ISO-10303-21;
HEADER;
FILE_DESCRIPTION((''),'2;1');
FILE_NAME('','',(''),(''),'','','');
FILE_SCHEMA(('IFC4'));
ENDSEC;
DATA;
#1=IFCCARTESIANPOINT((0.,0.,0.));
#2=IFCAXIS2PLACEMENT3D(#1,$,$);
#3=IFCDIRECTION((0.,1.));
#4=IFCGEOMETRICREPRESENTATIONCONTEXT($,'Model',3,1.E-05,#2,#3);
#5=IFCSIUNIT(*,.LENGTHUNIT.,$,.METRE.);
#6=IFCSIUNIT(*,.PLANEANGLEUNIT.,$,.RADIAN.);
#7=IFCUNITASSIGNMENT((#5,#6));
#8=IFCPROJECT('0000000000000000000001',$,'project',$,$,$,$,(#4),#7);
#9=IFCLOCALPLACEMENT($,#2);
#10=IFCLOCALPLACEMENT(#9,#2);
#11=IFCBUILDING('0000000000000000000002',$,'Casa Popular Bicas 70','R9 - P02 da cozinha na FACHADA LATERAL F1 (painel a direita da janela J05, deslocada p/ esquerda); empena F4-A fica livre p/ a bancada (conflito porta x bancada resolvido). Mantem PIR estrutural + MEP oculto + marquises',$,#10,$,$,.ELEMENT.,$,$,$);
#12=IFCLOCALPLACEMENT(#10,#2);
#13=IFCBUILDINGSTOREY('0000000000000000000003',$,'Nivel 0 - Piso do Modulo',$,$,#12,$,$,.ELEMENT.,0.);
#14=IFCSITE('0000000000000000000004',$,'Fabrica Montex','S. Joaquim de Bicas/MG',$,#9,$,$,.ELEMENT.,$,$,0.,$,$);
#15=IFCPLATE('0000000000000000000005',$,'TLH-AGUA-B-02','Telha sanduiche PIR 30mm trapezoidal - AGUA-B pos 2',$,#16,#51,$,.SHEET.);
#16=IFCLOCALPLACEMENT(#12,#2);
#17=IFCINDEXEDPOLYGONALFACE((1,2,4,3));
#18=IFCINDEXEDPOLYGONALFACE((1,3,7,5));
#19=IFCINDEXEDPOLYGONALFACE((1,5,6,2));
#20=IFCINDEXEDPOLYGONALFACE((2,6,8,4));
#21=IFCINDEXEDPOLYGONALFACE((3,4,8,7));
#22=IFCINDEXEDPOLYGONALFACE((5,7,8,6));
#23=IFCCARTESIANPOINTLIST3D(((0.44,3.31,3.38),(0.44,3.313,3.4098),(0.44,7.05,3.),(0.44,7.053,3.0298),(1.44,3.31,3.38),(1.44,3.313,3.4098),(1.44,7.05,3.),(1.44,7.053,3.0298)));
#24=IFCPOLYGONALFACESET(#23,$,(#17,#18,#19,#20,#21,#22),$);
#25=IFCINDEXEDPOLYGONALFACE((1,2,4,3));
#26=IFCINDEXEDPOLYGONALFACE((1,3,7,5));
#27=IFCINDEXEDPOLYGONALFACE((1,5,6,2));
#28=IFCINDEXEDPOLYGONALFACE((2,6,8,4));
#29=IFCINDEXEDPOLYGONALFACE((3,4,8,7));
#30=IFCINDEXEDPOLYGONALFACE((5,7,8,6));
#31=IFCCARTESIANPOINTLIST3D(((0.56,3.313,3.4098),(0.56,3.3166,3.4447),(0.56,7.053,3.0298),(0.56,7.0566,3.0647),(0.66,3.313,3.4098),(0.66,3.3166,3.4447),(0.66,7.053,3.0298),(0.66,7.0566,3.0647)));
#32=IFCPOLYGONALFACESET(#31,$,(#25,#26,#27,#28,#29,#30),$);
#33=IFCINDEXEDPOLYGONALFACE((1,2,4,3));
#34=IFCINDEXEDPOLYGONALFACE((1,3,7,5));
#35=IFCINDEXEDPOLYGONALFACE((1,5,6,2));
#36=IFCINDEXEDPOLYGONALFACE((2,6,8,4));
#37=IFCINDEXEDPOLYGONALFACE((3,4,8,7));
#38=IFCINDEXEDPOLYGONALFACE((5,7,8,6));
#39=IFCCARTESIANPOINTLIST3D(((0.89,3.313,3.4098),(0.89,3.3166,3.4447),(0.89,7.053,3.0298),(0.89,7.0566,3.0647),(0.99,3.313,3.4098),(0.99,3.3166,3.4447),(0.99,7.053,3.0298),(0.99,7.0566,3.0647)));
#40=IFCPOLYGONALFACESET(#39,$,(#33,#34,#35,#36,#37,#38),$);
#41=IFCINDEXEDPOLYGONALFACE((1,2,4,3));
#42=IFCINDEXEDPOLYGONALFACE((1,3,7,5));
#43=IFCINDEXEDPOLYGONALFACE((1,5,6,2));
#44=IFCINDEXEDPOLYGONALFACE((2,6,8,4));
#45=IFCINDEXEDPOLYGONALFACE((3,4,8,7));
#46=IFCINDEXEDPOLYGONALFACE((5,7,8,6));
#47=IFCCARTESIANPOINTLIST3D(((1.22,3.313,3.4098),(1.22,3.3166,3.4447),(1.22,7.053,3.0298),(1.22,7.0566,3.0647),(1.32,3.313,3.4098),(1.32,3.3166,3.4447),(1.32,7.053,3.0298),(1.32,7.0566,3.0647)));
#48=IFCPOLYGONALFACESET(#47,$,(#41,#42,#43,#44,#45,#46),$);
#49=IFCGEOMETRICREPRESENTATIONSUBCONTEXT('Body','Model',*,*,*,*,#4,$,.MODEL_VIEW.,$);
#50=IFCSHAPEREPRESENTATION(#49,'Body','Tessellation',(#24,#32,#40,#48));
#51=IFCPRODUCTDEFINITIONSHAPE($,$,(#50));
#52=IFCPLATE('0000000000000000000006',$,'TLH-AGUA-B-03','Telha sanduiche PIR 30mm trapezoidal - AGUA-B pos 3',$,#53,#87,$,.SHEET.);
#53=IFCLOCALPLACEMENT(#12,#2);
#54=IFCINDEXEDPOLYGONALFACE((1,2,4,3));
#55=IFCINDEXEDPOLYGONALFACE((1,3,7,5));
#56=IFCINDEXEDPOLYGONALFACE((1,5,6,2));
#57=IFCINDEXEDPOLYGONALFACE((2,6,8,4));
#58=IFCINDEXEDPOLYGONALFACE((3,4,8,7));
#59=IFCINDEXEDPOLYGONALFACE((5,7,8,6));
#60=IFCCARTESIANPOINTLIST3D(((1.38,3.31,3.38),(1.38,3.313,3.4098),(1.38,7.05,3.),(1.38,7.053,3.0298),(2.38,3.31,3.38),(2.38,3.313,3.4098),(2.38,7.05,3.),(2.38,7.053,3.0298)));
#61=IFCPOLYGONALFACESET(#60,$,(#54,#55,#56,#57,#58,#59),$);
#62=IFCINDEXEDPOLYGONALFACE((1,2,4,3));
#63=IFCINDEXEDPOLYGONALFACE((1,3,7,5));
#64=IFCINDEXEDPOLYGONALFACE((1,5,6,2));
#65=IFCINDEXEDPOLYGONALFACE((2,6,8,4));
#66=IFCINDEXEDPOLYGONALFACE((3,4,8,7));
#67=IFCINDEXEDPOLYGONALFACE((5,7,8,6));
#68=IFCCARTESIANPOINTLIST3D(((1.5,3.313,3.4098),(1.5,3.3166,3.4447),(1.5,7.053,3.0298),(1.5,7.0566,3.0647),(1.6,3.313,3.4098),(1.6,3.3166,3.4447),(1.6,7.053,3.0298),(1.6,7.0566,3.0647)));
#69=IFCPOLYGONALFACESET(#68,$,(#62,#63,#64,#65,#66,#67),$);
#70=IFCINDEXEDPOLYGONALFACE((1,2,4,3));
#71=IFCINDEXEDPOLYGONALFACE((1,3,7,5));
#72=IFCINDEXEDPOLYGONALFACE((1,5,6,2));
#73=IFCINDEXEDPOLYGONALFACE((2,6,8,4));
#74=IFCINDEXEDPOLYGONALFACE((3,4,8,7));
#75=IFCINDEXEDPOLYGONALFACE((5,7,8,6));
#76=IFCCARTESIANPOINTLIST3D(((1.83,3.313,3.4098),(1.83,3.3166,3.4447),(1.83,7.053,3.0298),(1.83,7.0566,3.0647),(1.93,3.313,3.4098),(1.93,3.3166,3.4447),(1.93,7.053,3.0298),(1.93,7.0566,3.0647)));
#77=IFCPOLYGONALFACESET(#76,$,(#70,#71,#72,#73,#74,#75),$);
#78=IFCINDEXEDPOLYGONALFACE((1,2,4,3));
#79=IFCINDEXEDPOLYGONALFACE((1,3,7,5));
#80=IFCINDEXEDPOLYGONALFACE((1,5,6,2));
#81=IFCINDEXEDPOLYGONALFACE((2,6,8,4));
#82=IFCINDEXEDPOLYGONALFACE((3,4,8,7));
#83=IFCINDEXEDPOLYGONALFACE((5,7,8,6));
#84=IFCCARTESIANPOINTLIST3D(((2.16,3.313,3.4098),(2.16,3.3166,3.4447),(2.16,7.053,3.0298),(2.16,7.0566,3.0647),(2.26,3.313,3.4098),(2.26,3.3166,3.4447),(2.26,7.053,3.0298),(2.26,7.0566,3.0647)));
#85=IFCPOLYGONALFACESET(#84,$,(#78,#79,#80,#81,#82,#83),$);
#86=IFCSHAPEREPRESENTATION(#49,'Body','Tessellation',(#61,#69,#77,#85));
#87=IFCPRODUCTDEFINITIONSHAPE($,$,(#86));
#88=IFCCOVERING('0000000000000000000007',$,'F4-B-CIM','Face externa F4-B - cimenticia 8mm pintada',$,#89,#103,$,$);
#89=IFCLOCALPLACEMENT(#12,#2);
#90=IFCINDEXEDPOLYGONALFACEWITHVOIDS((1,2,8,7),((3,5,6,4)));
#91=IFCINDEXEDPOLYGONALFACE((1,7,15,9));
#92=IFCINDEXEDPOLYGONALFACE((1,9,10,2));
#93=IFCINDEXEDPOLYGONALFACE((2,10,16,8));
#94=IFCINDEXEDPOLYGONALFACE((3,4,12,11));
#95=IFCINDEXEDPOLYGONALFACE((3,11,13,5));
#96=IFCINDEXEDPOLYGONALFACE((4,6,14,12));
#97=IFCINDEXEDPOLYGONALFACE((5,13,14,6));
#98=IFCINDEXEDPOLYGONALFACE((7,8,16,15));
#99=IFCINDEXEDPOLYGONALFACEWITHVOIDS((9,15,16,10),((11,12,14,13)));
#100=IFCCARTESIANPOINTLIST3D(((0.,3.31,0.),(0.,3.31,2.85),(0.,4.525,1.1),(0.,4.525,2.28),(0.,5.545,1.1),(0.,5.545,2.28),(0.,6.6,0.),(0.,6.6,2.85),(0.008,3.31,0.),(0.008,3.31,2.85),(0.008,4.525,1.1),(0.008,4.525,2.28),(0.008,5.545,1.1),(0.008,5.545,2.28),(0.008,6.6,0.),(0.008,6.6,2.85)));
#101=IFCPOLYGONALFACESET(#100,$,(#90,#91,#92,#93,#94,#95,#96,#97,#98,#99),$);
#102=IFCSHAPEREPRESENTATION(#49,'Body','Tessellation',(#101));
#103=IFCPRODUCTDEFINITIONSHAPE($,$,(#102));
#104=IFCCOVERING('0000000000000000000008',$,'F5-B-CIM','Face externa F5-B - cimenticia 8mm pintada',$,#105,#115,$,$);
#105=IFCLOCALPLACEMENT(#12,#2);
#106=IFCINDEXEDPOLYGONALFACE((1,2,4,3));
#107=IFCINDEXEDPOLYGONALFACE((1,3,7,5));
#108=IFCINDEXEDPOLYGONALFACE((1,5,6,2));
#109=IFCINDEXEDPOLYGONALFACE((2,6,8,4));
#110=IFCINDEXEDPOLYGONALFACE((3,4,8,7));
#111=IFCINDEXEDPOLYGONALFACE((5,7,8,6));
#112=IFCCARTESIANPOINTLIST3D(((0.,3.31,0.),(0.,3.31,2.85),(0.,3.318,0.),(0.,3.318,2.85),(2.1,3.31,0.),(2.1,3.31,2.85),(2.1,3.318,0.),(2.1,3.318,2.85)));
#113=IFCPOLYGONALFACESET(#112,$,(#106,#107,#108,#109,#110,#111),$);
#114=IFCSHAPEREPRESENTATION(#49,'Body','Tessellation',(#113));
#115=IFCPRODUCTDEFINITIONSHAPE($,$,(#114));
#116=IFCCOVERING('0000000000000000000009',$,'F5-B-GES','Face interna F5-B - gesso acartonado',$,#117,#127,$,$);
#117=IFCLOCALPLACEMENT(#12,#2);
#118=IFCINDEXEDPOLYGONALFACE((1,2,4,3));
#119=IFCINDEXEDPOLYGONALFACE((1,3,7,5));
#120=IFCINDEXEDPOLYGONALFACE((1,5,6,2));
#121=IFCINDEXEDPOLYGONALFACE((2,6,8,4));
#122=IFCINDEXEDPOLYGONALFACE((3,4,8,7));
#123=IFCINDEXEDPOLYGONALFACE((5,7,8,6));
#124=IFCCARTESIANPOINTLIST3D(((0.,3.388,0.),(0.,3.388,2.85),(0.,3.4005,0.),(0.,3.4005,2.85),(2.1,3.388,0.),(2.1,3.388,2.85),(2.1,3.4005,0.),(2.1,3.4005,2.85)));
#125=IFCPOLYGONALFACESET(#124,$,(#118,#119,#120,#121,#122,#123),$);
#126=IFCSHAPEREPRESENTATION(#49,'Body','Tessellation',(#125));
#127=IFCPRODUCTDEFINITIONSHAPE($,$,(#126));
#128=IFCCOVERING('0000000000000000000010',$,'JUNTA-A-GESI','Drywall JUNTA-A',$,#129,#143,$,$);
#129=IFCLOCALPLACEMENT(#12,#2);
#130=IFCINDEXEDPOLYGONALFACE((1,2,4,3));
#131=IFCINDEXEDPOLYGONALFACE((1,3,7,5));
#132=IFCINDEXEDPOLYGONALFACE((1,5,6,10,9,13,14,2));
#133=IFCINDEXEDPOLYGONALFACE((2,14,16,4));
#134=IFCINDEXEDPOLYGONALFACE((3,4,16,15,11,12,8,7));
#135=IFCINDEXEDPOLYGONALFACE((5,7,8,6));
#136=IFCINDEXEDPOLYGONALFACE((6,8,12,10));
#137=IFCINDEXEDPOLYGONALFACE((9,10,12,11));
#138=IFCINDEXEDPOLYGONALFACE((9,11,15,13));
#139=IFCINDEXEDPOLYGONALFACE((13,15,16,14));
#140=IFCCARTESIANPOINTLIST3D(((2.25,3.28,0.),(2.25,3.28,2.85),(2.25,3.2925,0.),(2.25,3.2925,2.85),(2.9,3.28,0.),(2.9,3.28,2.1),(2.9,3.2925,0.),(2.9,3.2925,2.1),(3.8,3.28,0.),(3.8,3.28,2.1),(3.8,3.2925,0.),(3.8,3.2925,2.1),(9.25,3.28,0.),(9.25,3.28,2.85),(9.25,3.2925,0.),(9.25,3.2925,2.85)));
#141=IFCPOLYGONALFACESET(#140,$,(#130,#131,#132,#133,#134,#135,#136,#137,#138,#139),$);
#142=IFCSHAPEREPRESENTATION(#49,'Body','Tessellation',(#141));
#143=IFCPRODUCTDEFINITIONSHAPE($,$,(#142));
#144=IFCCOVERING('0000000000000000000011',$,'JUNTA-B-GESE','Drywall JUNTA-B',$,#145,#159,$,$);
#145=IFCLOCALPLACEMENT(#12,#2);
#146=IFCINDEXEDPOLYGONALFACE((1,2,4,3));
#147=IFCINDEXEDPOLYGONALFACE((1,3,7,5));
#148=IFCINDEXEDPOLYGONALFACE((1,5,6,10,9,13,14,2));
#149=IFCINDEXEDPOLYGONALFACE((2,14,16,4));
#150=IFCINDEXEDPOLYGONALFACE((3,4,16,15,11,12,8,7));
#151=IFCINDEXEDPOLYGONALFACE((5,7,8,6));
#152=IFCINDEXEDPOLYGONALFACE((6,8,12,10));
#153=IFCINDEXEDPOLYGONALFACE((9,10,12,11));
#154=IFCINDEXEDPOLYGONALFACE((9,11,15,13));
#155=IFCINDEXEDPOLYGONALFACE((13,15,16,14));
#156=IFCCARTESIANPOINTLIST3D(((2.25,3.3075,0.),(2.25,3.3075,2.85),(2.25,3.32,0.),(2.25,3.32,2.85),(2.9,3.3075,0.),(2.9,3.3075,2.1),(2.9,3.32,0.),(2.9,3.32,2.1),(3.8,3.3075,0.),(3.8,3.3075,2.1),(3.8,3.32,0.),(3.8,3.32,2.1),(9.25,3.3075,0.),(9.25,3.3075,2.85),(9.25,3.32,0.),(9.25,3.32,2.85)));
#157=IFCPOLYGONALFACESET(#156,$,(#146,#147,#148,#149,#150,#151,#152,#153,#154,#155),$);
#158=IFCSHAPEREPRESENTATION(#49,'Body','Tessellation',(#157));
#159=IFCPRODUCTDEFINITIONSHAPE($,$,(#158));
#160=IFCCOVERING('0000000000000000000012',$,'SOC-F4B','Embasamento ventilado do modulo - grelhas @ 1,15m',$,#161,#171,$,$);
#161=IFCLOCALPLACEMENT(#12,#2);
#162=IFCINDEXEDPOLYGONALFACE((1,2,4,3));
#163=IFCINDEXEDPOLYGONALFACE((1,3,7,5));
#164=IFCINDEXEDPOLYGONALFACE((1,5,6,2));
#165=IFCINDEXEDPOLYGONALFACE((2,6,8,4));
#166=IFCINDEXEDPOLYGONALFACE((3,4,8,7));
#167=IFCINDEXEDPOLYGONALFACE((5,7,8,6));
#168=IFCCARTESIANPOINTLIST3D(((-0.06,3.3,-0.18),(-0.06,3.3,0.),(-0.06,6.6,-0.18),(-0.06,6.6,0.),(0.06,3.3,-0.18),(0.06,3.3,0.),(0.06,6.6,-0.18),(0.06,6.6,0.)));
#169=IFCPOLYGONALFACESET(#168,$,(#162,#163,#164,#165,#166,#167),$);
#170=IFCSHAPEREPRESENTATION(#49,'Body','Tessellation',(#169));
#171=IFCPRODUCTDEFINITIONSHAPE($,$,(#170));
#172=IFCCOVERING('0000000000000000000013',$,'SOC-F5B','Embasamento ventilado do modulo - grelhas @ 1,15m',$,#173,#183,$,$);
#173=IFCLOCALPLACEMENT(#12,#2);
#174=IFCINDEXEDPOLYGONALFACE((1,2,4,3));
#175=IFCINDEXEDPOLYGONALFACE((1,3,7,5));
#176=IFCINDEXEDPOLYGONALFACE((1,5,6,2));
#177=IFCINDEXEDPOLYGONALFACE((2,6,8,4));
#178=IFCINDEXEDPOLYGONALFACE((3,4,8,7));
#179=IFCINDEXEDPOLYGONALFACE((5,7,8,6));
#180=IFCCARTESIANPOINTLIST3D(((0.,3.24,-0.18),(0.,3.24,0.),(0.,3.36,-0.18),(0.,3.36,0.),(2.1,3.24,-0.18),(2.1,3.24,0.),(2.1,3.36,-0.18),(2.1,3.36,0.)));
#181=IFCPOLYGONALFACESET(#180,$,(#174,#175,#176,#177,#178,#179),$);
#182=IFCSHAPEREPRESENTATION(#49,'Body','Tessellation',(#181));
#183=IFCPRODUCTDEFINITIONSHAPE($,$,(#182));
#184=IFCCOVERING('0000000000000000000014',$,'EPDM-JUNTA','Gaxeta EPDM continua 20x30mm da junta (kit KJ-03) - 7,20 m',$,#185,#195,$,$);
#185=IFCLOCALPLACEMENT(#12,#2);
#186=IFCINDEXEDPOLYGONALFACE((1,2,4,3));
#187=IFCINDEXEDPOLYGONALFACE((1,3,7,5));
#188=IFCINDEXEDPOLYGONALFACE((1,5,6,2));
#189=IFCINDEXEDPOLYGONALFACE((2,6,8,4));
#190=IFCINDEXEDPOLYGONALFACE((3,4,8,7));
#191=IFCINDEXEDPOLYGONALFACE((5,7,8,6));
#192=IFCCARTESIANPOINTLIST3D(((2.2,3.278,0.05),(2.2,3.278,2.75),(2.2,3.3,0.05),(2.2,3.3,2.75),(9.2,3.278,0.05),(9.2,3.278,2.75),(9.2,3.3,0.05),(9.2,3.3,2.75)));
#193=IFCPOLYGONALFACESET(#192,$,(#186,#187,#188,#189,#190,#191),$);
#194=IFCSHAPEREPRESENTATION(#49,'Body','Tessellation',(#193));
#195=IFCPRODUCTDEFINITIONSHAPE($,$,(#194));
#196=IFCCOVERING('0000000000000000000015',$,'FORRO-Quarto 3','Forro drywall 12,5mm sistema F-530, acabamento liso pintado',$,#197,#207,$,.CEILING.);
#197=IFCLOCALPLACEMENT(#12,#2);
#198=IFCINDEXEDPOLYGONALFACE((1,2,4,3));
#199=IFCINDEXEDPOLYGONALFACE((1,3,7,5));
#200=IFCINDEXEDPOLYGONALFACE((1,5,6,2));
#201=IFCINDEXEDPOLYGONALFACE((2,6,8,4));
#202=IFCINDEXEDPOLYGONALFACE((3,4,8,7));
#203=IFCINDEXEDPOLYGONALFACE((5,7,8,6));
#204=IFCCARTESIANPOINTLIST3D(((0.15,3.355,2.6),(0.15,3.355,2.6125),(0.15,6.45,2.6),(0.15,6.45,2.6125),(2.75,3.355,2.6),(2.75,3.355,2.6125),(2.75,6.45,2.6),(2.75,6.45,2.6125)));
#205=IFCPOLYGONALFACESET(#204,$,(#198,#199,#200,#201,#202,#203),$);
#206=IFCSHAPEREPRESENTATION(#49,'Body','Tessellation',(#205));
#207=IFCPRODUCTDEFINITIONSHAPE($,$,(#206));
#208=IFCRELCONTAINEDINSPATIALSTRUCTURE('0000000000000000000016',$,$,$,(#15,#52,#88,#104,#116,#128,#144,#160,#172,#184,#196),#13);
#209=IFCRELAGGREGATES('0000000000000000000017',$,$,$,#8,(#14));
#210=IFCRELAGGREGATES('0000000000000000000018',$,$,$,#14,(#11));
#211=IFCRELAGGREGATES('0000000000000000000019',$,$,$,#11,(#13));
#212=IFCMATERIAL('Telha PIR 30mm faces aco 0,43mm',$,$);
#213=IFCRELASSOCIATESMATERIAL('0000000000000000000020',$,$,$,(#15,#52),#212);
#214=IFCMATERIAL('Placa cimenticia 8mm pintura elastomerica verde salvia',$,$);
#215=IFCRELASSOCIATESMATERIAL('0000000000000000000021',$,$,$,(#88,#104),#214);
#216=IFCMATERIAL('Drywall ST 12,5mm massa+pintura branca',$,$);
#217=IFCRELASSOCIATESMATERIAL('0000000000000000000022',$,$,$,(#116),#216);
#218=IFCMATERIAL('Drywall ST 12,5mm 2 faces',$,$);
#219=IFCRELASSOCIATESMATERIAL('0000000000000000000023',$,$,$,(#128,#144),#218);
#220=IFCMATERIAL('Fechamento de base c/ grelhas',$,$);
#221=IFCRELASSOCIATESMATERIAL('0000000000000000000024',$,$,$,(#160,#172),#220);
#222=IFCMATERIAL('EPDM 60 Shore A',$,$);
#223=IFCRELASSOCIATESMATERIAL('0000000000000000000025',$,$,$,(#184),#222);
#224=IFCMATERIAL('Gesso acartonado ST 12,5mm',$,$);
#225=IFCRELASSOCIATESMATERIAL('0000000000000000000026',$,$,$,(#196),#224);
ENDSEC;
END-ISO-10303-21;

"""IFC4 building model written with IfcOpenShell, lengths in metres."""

from ifc_helpers import new_model, si_unit, direction, frame, frame_2d, origin, origin_2d, place, context, subcontext, project, spatial, rectangle, extrude, material, element, save


model = new_model("IFC4")

# Units and contexts
model_context = context("Model", 3, precision=1e-05, world=origin(), true_north=direction((0.0, 1.0)))
body_context = subcontext(model_context, "Body", "Model", "MODEL_VIEW")
ifc_project = project(units=[si_unit("LENGTHUNIT", "METRE"), si_unit("PLANEANGLEUNIT", "RADIAN")], contexts=[model_context])

# Site, building, storey
site_placement = place(None, origin())
site = spatial("IfcSite", under=ifc_project, at=site_placement, Name="Fabrica Montex", Description="S. Joaquim de Bicas/MG", CompositionType="ELEMENT", RefElevation=0.0)
building_placement = place(site_placement, origin())
building = spatial("IfcBuilding", under=site, at=building_placement, Name="Casa Popular Bicas 70", Description="R9 - P02 da cozinha na FACHADA LATERAL F1 (painel a direita da janela J05, deslocada p/ esquerda); empena F4-A fica livre p/ a bancada (conflito porta x bancada resolvido). Mantem PIR estrutural + MEP oculto + marquises", CompositionType="ELEMENT")
storey_placement = place(building_placement, origin())
storey = spatial("IfcBuildingStorey", under=building, at=storey_placement, Name="Nivel 0 - Piso do Modulo", CompositionType="ELEMENT", Elevation=0.0)

# Plates
ifc_material_1 = material(Name="Telha PIR 30mm faces aco 0,43mm")
for number, where, z_axis, x_axis, name, description in (
    (1, (0.44, 3.31, 3.38), (0.0, 0.101084, 0.994878), (1.0, 0.0, 0.0), "TLH-AGUA-B-02", "Telha sanduiche PIR 30mm trapezoidal - AGUA-B pos 2"),
    (2, (1.38, 3.31, 3.38), (0.0, 0.101084, 0.994878), (1.0, 0.0, 0.0), "TLH-AGUA-B-03", "Telha sanduiche PIR 30mm trapezoidal - AGUA-B pos 3"),
):
    element("IfcPlate", number, at=place(storey_placement, frame(where, z_axis=z_axis, x_axis=x_axis)), inside=storey, material=ifc_material_1, Name=name, Description=description, PredefinedType="SHEET", context=body_context, shape_type="SweptSolid", body=[
        extrude(rectangle(XDim=1.0, YDim=3.7593, at=frame_2d((0.5, 1.8796))), origin(), (0.0, 0.0, 1.0), 0.03),
        extrude(rectangle(XDim=0.1, YDim=3.7593, at=frame_2d((0.17, 1.8796))), frame((0.0, 0.0, 0.03)), (0.0, 0.0, 1.0), 0.035),
        extrude(rectangle(XDim=0.1, YDim=3.7593, at=frame_2d((0.5, 1.8796))), frame((0.0, 0.0, 0.03)), (0.0, 0.0, 1.0), 0.035),
        extrude(rectangle(XDim=0.1, YDim=3.7593, at=frame_2d((0.83, 1.8796))), frame((0.0, 0.0, 0.03)), (0.0, 0.0, 1.0), 0.035),
    ])

# Covering, opening
ifc_material_2 = material(Name="Placa cimenticia 8mm pintura elastomerica verde salvia")
covering_1_placement = place(storey_placement, frame((0.004, 3.31, 0.0), x_axis=(0.0, 1.0, 0.0)))
covering_1 = element("IfcCovering", 3, at=covering_1_placement, inside=storey, material=ifc_material_2, Name="F4-B-CIM", Description="Face externa F4-B - cimenticia 8mm pintada", context=body_context, shape_type="SweptSolid", body=[
    extrude(rectangle(XDim=3.29, YDim=0.008, at=frame_2d((1.645, 0.0))), origin(), (0.0, 0.0, 1.0), 2.85),
])
opening_1_placement = place(storey_placement, frame((0.004, 4.535, 1.1), x_axis=(0.0, 1.0, 0.0)))
element("IfcOpeningElement", 4, at=opening_1_placement, cuts=covering_1, PredefinedType="OPENING", context=body_context, shape_type="SweptSolid", body=[
    extrude(rectangle(XDim=1.02, YDim=0.03, at=frame_2d((0.5, 0.0))), origin(), (0.0, 0.0, 1.0), 1.18),
])
ifc_material_3 = material(Name="Drywall ST 12,5mm massa+pintura branca")

# Coverings
covering_2_placement = place(storey_placement, frame((0.0, 3.314, 0.0), x_axis=(1.0, 0.0, 0.0)))
element("IfcCovering", 5, at=covering_2_placement, inside=storey, material=ifc_material_2, Name="F5-B-CIM", Description="Face externa F5-B - cimenticia 8mm pintada", context=body_context, shape_type="SweptSolid", body=[
    extrude(rectangle(XDim=2.1, YDim=0.008, at=frame_2d((1.05, 0.0))), origin(), (0.0, 0.0, 1.0), 2.85),
])
covering_3_placement = place(storey_placement, frame((0.0, 3.3942, 0.0), x_axis=(1.0, 0.0, 0.0)))
element("IfcCovering", 6, at=covering_3_placement, inside=storey, material=ifc_material_3, Name="F5-B-GES", Description="Face interna F5-B - gesso acartonado", context=body_context, shape_type="SweptSolid", body=[
    extrude(rectangle(XDim=2.1, YDim=0.0125, at=frame_2d((1.05, 0.0))), origin(), (0.0, 0.0, 1.0), 2.85),
])

# Coverings, openings
ifc_material_4 = material(Name="Drywall ST 12,5mm 2 faces")
covering_4_placement = place(storey_placement, frame((2.25, 3.2862, 0.0), x_axis=(1.0, 0.0, 0.0)))
covering_4 = element("IfcCovering", 7, at=covering_4_placement, inside=storey, material=ifc_material_4, Name="JUNTA-A-GESI", Description="Drywall JUNTA-A", context=body_context, shape_type="SweptSolid", body=[
    extrude(rectangle(XDim=7.0, YDim=0.0125, at=frame_2d((3.5, 0.0))), origin(), (0.0, 0.0, 1.0), 2.85),
])
opening_2_placement = place(storey_placement, frame((3.35, 3.2862, 0.0)))
element("IfcOpeningElement", 8, at=opening_2_placement, cuts=covering_4, PredefinedType="OPENING", context=body_context, shape_type="SweptSolid", body=[
    extrude(rectangle(XDim=0.9, YDim=0.0425, at=origin_2d()), origin(), (0.0, 0.0, 1.0), 2.1),
])
covering_5_placement = place(storey_placement, frame((2.25, 3.3137, 0.0), x_axis=(1.0, 0.0, 0.0)))
covering_5 = element("IfcCovering", 9, at=covering_5_placement, inside=storey, material=ifc_material_4, Name="JUNTA-B-GESE", Description="Drywall JUNTA-B", context=body_context, shape_type="SweptSolid", body=[
    extrude(rectangle(XDim=7.0, YDim=0.0125, at=frame_2d((3.5, 0.0))), origin(), (0.0, 0.0, 1.0), 2.85),
])
opening_3_placement = place(storey_placement, frame((3.35, 3.3137, 0.0)))
element("IfcOpeningElement", 10, at=opening_3_placement, cuts=covering_5, PredefinedType="OPENING", context=body_context, shape_type="SweptSolid", body=[
    extrude(rectangle(XDim=0.9, YDim=0.0425, at=origin_2d()), origin(), (0.0, 0.0, 1.0), 2.1),
])

# Coverings
ifc_material_5 = material(Name="Fechamento de base c/ grelhas")
covering_6_placement = place(storey_placement, frame((0.0, 3.3, -0.18), x_axis=(0.0, 1.0, 0.0)))
element("IfcCovering", 11, at=covering_6_placement, inside=storey, material=ifc_material_5, Name="SOC-F4B", Description="Embasamento ventilado do modulo - grelhas @ 1,15m", context=body_context, shape_type="SweptSolid", body=[
    extrude(rectangle(XDim=3.3, YDim=0.12, at=frame_2d((1.65, 0.0))), origin(), (0.0, 0.0, 1.0), 0.18),
])
covering_7_placement = place(storey_placement, frame((0.0, 3.3, -0.18), x_axis=(1.0, 0.0, 0.0)))
element("IfcCovering", 12, at=covering_7_placement, inside=storey, material=ifc_material_5, Name="SOC-F5B", Description="Embasamento ventilado do modulo - grelhas @ 1,15m", context=body_context, shape_type="SweptSolid", body=[
    extrude(rectangle(XDim=2.1, YDim=0.12, at=frame_2d((1.05, 0.0))), origin(), (0.0, 0.0, 1.0), 0.18),
])
ifc_material_6 = material(Name="EPDM 60 Shore A")
covering_8_placement = place(storey_placement, frame((2.2, 3.289, 0.05), x_axis=(1.0, 0.0, 0.0)))
element("IfcCovering", 13, at=covering_8_placement, inside=storey, material=ifc_material_6, Name="EPDM-JUNTA", Description="Gaxeta EPDM continua 20x30mm da junta (kit KJ-03) - 7,20 m", context=body_context, shape_type="SweptSolid", body=[
    extrude(rectangle(XDim=7.0, YDim=0.022, at=frame_2d((3.5, 0.0))), origin(), (0.0, 0.0, 1.0), 2.7),
])
ifc_material_7 = material(Name="Gesso acartonado ST 12,5mm")
covering_9_placement = place(storey_placement, frame((0.15, 3.355, 2.6)))
element("IfcCovering", 14, at=covering_9_placement, inside=storey, material=ifc_material_7, Name="FORRO-Quarto 3", Description="Forro drywall 12,5mm sistema F-530, acabamento liso pintado", PredefinedType="CEILING", context=body_context, shape_type="SweptSolid", body=[
    extrude(rectangle(XDim=2.6, YDim=3.095, at=frame_2d((1.3, 1.5475))), origin(), (0.0, 0.0, 1.0), 0.0125),
])

save(model, "model.ifc")
